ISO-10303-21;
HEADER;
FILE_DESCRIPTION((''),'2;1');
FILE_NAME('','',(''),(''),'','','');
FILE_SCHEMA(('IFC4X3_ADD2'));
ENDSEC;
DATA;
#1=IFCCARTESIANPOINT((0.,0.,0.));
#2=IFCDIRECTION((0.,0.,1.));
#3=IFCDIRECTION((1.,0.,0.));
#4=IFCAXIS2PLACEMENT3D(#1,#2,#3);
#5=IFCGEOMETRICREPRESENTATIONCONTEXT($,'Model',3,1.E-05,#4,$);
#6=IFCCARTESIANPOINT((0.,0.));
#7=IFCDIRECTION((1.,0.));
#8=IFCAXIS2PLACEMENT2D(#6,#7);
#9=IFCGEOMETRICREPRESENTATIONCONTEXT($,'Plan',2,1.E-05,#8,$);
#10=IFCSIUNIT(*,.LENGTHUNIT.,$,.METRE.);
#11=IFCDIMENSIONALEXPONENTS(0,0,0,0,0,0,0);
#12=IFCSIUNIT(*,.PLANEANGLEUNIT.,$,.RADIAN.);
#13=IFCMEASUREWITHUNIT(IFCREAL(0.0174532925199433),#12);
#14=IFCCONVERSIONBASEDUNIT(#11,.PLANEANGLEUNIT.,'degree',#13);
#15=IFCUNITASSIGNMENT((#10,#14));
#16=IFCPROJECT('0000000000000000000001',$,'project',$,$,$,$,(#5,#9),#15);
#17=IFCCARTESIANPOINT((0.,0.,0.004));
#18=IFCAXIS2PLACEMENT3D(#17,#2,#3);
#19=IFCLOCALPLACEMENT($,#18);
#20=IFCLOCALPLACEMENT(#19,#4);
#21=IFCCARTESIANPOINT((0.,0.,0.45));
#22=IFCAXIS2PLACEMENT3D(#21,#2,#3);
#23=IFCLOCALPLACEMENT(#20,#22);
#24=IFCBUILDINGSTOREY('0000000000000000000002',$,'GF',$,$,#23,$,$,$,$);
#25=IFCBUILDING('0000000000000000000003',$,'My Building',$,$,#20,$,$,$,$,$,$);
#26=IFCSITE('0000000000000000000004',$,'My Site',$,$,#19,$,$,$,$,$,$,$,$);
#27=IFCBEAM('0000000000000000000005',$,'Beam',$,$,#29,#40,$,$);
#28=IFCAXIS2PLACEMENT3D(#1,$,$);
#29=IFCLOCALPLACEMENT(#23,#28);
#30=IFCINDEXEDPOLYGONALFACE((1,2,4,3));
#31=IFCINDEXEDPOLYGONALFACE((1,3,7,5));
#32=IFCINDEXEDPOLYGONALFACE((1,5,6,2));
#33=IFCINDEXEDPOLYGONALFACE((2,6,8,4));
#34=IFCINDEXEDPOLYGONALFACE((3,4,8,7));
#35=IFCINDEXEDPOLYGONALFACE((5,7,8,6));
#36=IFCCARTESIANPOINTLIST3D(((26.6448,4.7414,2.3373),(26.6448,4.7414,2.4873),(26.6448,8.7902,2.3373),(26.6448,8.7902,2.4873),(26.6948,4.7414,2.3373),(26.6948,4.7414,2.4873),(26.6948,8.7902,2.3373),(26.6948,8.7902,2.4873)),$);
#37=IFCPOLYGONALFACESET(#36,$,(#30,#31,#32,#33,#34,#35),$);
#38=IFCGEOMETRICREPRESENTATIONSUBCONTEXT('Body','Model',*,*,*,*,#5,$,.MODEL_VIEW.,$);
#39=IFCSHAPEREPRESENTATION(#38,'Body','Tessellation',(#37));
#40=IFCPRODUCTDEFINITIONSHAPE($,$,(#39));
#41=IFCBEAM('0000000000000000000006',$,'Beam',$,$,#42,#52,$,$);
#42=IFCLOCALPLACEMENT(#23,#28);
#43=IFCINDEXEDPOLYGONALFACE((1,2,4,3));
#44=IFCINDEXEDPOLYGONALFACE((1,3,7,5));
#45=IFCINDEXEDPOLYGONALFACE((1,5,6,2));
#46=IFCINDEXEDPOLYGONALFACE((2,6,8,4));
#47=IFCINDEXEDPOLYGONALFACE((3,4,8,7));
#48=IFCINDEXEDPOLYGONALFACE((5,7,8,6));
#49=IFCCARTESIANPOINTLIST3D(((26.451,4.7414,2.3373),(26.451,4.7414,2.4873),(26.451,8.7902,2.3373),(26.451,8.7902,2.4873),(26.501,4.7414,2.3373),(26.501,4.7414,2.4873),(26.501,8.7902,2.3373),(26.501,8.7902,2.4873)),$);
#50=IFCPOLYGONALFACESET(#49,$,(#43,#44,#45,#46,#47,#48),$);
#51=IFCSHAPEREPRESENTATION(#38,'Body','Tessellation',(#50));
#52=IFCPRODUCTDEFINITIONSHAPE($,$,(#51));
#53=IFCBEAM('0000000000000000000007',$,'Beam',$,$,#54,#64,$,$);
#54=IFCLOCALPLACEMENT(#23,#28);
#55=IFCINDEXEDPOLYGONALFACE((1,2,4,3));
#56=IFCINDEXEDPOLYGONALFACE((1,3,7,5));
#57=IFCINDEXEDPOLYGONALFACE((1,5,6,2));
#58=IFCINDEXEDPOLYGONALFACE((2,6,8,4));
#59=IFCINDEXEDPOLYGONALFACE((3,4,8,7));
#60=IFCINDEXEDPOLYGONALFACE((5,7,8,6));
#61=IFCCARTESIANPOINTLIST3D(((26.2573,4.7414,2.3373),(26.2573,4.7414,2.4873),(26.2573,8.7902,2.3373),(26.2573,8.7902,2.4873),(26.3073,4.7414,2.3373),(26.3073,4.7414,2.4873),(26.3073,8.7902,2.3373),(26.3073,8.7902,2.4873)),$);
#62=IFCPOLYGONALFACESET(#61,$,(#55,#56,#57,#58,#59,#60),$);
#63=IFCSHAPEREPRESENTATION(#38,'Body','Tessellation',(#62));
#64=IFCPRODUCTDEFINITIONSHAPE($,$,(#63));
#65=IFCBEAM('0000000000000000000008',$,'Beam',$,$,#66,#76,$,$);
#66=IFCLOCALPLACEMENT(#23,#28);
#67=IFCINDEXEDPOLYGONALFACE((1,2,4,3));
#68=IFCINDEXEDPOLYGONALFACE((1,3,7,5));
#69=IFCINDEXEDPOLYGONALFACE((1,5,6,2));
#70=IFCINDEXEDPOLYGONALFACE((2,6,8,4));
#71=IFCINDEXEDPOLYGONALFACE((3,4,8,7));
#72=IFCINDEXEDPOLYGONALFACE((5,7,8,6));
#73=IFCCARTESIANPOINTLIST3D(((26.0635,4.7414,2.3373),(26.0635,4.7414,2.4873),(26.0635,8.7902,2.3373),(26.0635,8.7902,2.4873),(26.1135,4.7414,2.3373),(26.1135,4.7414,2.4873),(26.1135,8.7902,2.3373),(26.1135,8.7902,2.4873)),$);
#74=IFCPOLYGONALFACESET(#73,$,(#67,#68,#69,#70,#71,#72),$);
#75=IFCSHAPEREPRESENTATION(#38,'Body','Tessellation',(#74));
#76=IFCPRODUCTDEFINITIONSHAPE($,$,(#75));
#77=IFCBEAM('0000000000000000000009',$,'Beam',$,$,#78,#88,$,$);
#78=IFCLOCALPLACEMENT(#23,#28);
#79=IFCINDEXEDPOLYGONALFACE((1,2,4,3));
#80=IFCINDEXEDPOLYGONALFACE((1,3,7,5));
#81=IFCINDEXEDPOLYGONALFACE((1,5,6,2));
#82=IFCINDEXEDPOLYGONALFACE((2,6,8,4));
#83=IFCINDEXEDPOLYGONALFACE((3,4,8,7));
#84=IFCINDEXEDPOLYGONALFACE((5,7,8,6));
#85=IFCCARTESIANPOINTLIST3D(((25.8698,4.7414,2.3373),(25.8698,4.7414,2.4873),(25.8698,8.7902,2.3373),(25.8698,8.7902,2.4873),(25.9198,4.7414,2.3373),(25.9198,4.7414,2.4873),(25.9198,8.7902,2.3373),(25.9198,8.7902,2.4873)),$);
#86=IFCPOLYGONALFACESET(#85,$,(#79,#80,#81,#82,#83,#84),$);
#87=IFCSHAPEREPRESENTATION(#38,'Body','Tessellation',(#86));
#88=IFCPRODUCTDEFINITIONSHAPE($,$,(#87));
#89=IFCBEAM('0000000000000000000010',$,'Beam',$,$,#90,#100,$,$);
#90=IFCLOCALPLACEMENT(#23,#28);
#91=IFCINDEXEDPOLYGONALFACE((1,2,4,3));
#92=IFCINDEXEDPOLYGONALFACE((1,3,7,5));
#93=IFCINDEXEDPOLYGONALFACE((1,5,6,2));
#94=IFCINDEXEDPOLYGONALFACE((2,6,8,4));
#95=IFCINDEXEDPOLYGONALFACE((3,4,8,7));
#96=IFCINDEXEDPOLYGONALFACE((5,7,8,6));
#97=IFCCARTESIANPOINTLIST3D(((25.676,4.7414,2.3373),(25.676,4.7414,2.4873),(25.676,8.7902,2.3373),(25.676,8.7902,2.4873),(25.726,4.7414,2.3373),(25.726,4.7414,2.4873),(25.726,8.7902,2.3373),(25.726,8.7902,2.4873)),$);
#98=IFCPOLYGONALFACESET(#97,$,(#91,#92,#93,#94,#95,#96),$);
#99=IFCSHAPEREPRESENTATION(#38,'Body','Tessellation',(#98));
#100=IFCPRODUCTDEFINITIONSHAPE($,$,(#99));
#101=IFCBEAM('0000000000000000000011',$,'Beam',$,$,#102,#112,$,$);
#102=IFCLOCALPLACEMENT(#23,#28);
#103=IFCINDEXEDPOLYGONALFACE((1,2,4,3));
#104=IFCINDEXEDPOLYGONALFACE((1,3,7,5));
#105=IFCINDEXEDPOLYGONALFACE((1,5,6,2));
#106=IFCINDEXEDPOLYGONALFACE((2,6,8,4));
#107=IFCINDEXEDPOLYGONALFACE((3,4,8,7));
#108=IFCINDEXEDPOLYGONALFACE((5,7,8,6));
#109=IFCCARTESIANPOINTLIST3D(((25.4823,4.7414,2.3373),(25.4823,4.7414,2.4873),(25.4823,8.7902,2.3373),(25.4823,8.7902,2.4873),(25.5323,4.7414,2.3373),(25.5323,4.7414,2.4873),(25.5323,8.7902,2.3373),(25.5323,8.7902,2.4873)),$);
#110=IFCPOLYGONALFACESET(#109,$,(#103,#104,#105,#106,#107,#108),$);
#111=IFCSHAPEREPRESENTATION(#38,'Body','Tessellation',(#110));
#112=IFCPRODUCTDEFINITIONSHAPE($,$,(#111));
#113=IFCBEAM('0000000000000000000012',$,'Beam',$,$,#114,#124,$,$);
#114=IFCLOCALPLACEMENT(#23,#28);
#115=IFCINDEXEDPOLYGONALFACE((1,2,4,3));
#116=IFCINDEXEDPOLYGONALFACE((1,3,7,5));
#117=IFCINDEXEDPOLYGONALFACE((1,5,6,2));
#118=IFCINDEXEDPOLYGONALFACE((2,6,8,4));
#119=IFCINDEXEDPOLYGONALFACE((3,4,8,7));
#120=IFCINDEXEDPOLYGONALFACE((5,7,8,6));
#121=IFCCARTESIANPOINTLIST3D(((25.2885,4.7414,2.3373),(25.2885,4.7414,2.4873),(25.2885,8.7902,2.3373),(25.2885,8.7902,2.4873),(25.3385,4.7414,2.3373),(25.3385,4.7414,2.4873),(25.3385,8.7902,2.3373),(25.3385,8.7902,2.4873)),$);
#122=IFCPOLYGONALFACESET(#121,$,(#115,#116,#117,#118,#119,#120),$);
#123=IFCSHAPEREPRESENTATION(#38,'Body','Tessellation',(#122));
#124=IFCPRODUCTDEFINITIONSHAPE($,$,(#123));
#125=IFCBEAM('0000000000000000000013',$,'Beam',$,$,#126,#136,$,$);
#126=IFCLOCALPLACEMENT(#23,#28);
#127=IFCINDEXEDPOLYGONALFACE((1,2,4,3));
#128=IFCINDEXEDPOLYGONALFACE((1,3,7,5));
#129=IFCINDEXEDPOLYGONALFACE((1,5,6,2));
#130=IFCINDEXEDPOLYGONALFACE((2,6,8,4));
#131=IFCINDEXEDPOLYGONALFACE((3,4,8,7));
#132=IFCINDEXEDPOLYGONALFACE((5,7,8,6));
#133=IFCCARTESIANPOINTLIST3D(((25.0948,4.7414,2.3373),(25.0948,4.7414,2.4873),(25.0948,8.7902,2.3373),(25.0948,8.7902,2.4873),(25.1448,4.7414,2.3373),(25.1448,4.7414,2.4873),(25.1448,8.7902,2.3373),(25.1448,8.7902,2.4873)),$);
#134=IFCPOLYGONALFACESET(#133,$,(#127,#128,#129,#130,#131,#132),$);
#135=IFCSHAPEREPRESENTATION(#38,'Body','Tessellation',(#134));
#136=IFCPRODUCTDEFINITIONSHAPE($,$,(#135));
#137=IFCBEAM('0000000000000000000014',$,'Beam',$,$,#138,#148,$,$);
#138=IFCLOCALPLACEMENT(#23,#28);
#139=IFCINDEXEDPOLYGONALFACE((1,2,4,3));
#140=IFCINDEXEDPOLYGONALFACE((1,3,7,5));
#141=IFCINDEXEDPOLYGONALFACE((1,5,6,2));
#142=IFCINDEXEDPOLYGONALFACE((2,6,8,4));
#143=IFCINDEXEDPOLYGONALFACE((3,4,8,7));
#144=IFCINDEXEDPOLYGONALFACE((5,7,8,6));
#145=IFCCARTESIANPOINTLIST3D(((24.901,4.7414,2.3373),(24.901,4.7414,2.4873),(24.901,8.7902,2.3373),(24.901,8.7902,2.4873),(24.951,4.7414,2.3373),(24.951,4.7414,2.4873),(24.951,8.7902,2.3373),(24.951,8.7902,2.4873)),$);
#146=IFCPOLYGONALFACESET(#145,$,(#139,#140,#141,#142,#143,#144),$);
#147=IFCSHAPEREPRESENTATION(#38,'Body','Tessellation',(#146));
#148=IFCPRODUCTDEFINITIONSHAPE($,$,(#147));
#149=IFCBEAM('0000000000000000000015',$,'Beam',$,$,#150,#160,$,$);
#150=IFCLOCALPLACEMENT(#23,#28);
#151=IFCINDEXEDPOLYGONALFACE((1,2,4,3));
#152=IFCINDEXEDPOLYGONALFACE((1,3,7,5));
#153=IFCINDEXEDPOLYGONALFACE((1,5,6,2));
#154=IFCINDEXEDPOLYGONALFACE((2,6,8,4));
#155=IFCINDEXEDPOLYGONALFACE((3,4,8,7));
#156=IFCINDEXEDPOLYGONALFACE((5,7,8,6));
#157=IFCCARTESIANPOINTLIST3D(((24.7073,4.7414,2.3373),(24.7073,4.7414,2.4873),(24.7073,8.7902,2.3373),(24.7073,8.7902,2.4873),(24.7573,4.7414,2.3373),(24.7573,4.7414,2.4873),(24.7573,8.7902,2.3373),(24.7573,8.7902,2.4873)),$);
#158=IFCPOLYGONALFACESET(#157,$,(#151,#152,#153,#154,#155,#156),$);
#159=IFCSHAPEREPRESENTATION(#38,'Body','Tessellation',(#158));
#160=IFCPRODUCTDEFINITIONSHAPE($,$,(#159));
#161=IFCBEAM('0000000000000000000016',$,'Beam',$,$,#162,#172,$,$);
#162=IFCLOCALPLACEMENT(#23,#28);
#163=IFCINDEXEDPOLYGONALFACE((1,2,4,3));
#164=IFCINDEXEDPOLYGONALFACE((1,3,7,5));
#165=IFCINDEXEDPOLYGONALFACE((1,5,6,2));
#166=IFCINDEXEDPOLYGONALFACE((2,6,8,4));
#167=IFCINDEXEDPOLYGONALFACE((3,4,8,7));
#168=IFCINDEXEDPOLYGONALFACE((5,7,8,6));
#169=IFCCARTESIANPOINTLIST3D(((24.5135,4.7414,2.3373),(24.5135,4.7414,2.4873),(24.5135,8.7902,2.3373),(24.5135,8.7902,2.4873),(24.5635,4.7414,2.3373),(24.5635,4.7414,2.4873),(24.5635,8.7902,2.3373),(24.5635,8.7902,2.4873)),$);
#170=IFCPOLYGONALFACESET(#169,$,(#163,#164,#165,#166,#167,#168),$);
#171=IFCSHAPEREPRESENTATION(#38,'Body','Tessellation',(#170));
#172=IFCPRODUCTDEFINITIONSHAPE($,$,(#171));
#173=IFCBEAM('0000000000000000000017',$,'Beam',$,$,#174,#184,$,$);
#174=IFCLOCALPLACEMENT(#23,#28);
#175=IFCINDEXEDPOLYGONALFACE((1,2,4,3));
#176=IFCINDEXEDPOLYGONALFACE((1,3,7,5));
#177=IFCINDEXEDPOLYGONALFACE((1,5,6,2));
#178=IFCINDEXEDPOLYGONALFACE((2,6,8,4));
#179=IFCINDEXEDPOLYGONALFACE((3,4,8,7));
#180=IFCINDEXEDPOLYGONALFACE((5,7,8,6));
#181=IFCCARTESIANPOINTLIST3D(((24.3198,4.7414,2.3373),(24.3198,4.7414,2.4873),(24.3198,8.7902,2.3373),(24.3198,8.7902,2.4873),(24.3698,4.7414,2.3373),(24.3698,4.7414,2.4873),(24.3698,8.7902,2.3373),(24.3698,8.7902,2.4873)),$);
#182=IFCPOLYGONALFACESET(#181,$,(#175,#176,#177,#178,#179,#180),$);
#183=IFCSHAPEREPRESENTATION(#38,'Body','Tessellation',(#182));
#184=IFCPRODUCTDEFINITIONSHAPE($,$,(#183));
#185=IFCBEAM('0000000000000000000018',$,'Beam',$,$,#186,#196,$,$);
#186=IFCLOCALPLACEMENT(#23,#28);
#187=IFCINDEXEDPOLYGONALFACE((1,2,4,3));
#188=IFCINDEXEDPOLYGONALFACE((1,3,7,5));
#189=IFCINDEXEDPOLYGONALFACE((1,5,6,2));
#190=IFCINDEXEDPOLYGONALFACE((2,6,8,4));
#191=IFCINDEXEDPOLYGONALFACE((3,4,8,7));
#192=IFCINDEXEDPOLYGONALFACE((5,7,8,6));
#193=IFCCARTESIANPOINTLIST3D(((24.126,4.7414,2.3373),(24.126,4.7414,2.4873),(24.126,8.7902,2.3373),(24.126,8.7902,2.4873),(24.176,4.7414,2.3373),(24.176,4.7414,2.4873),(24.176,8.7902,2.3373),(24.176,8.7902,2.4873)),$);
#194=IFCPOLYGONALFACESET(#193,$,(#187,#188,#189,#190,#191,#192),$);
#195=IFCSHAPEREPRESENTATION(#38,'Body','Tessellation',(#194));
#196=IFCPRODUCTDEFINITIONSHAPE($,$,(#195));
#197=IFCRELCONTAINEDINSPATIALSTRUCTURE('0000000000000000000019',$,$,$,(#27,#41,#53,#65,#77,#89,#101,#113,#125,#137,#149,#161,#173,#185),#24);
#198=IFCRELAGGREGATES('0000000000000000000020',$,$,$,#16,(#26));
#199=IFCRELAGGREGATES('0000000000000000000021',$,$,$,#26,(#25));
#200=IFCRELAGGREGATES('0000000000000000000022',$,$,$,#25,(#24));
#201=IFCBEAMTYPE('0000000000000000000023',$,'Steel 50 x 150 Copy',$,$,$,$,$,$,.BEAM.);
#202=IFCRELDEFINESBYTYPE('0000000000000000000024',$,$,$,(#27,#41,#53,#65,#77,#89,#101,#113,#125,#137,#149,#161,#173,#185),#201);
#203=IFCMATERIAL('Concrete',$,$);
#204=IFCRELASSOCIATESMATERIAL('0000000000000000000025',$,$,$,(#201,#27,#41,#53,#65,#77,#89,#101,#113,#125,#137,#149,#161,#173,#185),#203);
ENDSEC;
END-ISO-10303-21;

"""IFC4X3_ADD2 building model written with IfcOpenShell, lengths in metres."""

from ifc_helpers import new_model, entity, si_unit, converted_unit, frame, origin_with_axes, origin_2d_with_axis, place, context, subcontext, project, spatial, rectangle, extrude, material, material_profile, profile_set, profile_usage, type_object, element, save


model = new_model("IFC4X3_ADD2")

# Units and contexts
model_context = context("Model", 3, precision=1e-05, world=origin_with_axes())
plan_context = context("Plan", 2, precision=1e-05, world=origin_2d_with_axis())
body_context = subcontext(model_context, "Body", "Model", "MODEL_VIEW")
ifc_project = project(units=[si_unit("LENGTHUNIT", "METRE"), converted_unit("PLANEANGLEUNIT", "degree", entity("IfcReal", 0.0174532925199433), si_unit("PLANEANGLEUNIT", "RADIAN"), dimensions=[0, 0, 0, 0, 0, 0, 0])], contexts=[model_context, plan_context])

# Site, building, storey
site_placement = place(None, frame((0.0, 0.0, 0.004), z_axis=(0.0, 0.0, 1.0), x_axis=(1.0, 0.0, 0.0)))
site = spatial("IfcSite", under=ifc_project, at=site_placement, Name="My Site")
building_placement = place(site_placement, origin_with_axes())
building = spatial("IfcBuilding", under=site, at=building_placement, Name="My Building")
storey_placement = place(building_placement, frame((0.0, 0.0, 0.45), z_axis=(0.0, 0.0, 1.0), x_axis=(1.0, 0.0, 0.0)))
storey = spatial("IfcBuildingStorey", under=building, at=storey_placement, Name="GF")

# Beams
ifc_material = material(Name="Concrete")
ifc_material_profile = material_profile(ifc_material, rectangle(XDim=0.05, YDim=0.15))
ifc_profile_set = profile_set([ifc_material_profile])
ifc_profile_usage_1 = profile_usage(ifc_profile_set)
beam_type = type_object("IfcBeamType", Name="Steel 50 x 150 Copy", PredefinedType="BEAM", material=ifc_profile_set)
beam_1_placement = place(storey_placement, frame((26.6698, 8.7902, 2.4123), z_axis=(0.0, -1.0, 0.0), x_axis=(1.0, 0.0, 0.0)))
element("IfcBeam", 1, at=beam_1_placement, inside=storey, type_object=beam_type, material=ifc_profile_usage_1, Name="Beam", context=body_context, shape_type="SweptSolid", body=[
    extrude(rectangle(XDim=0.05, YDim=0.15), origin_with_axes(), (0.0, 0.0, 1.0), 4.0488),
])
ifc_profile_usage_2 = profile_usage(ifc_profile_set)
beam_2_placement = place(storey_placement, frame((26.476, 8.7902, 2.4123), z_axis=(0.0, -1.0, 0.0), x_axis=(1.0, 0.0, 0.0)))
element("IfcBeam", 2, at=beam_2_placement, inside=storey, type_object=beam_type, material=ifc_profile_usage_2, Name="Beam", context=body_context, shape_type="SweptSolid", body=[
    extrude(rectangle(XDim=0.05, YDim=0.15), origin_with_axes(), (0.0, 0.0, 1.0), 4.0488),
])
ifc_profile_usage_3 = profile_usage(ifc_profile_set)
beam_3_placement = place(storey_placement, frame((26.2823, 8.7902, 2.4123), z_axis=(0.0, -1.0, 0.0), x_axis=(1.0, 0.0, 0.0)))
element("IfcBeam", 3, at=beam_3_placement, inside=storey, type_object=beam_type, material=ifc_profile_usage_3, Name="Beam", context=body_context, shape_type="SweptSolid", body=[
    extrude(rectangle(XDim=0.05, YDim=0.15), origin_with_axes(), (0.0, 0.0, 1.0), 4.0488),
])
ifc_profile_usage_4 = profile_usage(ifc_profile_set)
beam_4_placement = place(storey_placement, frame((26.0885, 8.7902, 2.4123), z_axis=(0.0, -1.0, 0.0), x_axis=(1.0, 0.0, 0.0)))
element("IfcBeam", 4, at=beam_4_placement, inside=storey, type_object=beam_type, material=ifc_profile_usage_4, Name="Beam", context=body_context, shape_type="SweptSolid", body=[
    extrude(rectangle(XDim=0.05, YDim=0.15), origin_with_axes(), (0.0, 0.0, 1.0), 4.0488),
])
ifc_profile_usage_5 = profile_usage(ifc_profile_set)
beam_5_placement = place(storey_placement, frame((25.8948, 8.7902, 2.4123), z_axis=(0.0, -1.0, 0.0), x_axis=(1.0, 0.0, 0.0)))
element("IfcBeam", 5, at=beam_5_placement, inside=storey, type_object=beam_type, material=ifc_profile_usage_5, Name="Beam", context=body_context, shape_type="SweptSolid", body=[
    extrude(rectangle(XDim=0.05, YDim=0.15), origin_with_axes(), (0.0, 0.0, 1.0), 4.0488),
])
ifc_profile_usage_6 = profile_usage(ifc_profile_set)
beam_6_placement = place(storey_placement, frame((25.701, 8.7902, 2.4123), z_axis=(0.0, -1.0, 0.0), x_axis=(1.0, 0.0, 0.0)))
element("IfcBeam", 6, at=beam_6_placement, inside=storey, type_object=beam_type, material=ifc_profile_usage_6, Name="Beam", context=body_context, shape_type="SweptSolid", body=[
    extrude(rectangle(XDim=0.05, YDim=0.15), origin_with_axes(), (0.0, 0.0, 1.0), 4.0488),
])
ifc_profile_usage_7 = profile_usage(ifc_profile_set)
beam_7_placement = place(storey_placement, frame((25.5073, 8.7902, 2.4123), z_axis=(0.0, -1.0, 0.0), x_axis=(1.0, 0.0, 0.0)))
element("IfcBeam", 7, at=beam_7_placement, inside=storey, type_object=beam_type, material=ifc_profile_usage_7, Name="Beam", context=body_context, shape_type="SweptSolid", body=[
    extrude(rectangle(XDim=0.05, YDim=0.15), origin_with_axes(), (0.0, 0.0, 1.0), 4.0488),
])
ifc_profile_usage_8 = profile_usage(ifc_profile_set)
beam_8_placement = place(storey_placement, frame((25.3135, 8.7902, 2.4123), z_axis=(0.0, -1.0, 0.0), x_axis=(1.0, 0.0, 0.0)))
element("IfcBeam", 8, at=beam_8_placement, inside=storey, type_object=beam_type, material=ifc_profile_usage_8, Name="Beam", context=body_context, shape_type="SweptSolid", body=[
    extrude(rectangle(XDim=0.05, YDim=0.15), origin_with_axes(), (0.0, 0.0, 1.0), 4.0488),
])
ifc_profile_usage_9 = profile_usage(ifc_profile_set)
beam_9_placement = place(storey_placement, frame((25.1198, 8.7902, 2.4123), z_axis=(0.0, -1.0, 0.0), x_axis=(1.0, 0.0, 0.0)))
element("IfcBeam", 9, at=beam_9_placement, inside=storey, type_object=beam_type, material=ifc_profile_usage_9, Name="Beam", context=body_context, shape_type="SweptSolid", body=[
    extrude(rectangle(XDim=0.05, YDim=0.15), origin_with_axes(), (0.0, 0.0, 1.0), 4.0488),
])
ifc_profile_usage_10 = profile_usage(ifc_profile_set)
beam_10_placement = place(storey_placement, frame((24.926, 8.7902, 2.4123), z_axis=(0.0, -1.0, 0.0), x_axis=(1.0, 0.0, 0.0)))
element("IfcBeam", 10, at=beam_10_placement, inside=storey, type_object=beam_type, material=ifc_profile_usage_10, Name="Beam", context=body_context, shape_type="SweptSolid", body=[
    extrude(rectangle(XDim=0.05, YDim=0.15), origin_with_axes(), (0.0, 0.0, 1.0), 4.0488),
])
ifc_profile_usage_11 = profile_usage(ifc_profile_set)
beam_11_placement = place(storey_placement, frame((24.7323, 8.7902, 2.4123), z_axis=(0.0, -1.0, 0.0), x_axis=(1.0, 0.0, 0.0)))
element("IfcBeam", 11, at=beam_11_placement, inside=storey, type_object=beam_type, material=ifc_profile_usage_11, Name="Beam", context=body_context, shape_type="SweptSolid", body=[
    extrude(rectangle(XDim=0.05, YDim=0.15), origin_with_axes(), (0.0, 0.0, 1.0), 4.0488),
])
ifc_profile_usage_12 = profile_usage(ifc_profile_set)
beam_12_placement = place(storey_placement, frame((24.5385, 8.7902, 2.4123), z_axis=(0.0, -1.0, 0.0), x_axis=(1.0, 0.0, 0.0)))
element("IfcBeam", 12, at=beam_12_placement, inside=storey, type_object=beam_type, material=ifc_profile_usage_12, Name="Beam", context=body_context, shape_type="SweptSolid", body=[
    extrude(rectangle(XDim=0.05, YDim=0.15), origin_with_axes(), (0.0, 0.0, 1.0), 4.0488),
])
ifc_profile_usage_13 = profile_usage(ifc_profile_set)
beam_13_placement = place(storey_placement, frame((24.3448, 8.7902, 2.4123), z_axis=(0.0, -1.0, 0.0), x_axis=(1.0, 0.0, 0.0)))
element("IfcBeam", 13, at=beam_13_placement, inside=storey, type_object=beam_type, material=ifc_profile_usage_13, Name="Beam", context=body_context, shape_type="SweptSolid", body=[
    extrude(rectangle(XDim=0.05, YDim=0.15), origin_with_axes(), (0.0, 0.0, 1.0), 4.0488),
])
ifc_profile_usage_14 = profile_usage(ifc_profile_set)
beam_14_placement = place(storey_placement, frame((24.151, 8.7902, 2.4123), z_axis=(0.0, -1.0, 0.0), x_axis=(1.0, 0.0, 0.0)))
element("IfcBeam", 14, at=beam_14_placement, inside=storey, type_object=beam_type, material=ifc_profile_usage_14, Name="Beam", context=body_context, shape_type="SweptSolid", body=[
    extrude(rectangle(XDim=0.05, YDim=0.15), origin_with_axes(), (0.0, 0.0, 1.0), 4.0488),
])

save(model, "model.ifc")
